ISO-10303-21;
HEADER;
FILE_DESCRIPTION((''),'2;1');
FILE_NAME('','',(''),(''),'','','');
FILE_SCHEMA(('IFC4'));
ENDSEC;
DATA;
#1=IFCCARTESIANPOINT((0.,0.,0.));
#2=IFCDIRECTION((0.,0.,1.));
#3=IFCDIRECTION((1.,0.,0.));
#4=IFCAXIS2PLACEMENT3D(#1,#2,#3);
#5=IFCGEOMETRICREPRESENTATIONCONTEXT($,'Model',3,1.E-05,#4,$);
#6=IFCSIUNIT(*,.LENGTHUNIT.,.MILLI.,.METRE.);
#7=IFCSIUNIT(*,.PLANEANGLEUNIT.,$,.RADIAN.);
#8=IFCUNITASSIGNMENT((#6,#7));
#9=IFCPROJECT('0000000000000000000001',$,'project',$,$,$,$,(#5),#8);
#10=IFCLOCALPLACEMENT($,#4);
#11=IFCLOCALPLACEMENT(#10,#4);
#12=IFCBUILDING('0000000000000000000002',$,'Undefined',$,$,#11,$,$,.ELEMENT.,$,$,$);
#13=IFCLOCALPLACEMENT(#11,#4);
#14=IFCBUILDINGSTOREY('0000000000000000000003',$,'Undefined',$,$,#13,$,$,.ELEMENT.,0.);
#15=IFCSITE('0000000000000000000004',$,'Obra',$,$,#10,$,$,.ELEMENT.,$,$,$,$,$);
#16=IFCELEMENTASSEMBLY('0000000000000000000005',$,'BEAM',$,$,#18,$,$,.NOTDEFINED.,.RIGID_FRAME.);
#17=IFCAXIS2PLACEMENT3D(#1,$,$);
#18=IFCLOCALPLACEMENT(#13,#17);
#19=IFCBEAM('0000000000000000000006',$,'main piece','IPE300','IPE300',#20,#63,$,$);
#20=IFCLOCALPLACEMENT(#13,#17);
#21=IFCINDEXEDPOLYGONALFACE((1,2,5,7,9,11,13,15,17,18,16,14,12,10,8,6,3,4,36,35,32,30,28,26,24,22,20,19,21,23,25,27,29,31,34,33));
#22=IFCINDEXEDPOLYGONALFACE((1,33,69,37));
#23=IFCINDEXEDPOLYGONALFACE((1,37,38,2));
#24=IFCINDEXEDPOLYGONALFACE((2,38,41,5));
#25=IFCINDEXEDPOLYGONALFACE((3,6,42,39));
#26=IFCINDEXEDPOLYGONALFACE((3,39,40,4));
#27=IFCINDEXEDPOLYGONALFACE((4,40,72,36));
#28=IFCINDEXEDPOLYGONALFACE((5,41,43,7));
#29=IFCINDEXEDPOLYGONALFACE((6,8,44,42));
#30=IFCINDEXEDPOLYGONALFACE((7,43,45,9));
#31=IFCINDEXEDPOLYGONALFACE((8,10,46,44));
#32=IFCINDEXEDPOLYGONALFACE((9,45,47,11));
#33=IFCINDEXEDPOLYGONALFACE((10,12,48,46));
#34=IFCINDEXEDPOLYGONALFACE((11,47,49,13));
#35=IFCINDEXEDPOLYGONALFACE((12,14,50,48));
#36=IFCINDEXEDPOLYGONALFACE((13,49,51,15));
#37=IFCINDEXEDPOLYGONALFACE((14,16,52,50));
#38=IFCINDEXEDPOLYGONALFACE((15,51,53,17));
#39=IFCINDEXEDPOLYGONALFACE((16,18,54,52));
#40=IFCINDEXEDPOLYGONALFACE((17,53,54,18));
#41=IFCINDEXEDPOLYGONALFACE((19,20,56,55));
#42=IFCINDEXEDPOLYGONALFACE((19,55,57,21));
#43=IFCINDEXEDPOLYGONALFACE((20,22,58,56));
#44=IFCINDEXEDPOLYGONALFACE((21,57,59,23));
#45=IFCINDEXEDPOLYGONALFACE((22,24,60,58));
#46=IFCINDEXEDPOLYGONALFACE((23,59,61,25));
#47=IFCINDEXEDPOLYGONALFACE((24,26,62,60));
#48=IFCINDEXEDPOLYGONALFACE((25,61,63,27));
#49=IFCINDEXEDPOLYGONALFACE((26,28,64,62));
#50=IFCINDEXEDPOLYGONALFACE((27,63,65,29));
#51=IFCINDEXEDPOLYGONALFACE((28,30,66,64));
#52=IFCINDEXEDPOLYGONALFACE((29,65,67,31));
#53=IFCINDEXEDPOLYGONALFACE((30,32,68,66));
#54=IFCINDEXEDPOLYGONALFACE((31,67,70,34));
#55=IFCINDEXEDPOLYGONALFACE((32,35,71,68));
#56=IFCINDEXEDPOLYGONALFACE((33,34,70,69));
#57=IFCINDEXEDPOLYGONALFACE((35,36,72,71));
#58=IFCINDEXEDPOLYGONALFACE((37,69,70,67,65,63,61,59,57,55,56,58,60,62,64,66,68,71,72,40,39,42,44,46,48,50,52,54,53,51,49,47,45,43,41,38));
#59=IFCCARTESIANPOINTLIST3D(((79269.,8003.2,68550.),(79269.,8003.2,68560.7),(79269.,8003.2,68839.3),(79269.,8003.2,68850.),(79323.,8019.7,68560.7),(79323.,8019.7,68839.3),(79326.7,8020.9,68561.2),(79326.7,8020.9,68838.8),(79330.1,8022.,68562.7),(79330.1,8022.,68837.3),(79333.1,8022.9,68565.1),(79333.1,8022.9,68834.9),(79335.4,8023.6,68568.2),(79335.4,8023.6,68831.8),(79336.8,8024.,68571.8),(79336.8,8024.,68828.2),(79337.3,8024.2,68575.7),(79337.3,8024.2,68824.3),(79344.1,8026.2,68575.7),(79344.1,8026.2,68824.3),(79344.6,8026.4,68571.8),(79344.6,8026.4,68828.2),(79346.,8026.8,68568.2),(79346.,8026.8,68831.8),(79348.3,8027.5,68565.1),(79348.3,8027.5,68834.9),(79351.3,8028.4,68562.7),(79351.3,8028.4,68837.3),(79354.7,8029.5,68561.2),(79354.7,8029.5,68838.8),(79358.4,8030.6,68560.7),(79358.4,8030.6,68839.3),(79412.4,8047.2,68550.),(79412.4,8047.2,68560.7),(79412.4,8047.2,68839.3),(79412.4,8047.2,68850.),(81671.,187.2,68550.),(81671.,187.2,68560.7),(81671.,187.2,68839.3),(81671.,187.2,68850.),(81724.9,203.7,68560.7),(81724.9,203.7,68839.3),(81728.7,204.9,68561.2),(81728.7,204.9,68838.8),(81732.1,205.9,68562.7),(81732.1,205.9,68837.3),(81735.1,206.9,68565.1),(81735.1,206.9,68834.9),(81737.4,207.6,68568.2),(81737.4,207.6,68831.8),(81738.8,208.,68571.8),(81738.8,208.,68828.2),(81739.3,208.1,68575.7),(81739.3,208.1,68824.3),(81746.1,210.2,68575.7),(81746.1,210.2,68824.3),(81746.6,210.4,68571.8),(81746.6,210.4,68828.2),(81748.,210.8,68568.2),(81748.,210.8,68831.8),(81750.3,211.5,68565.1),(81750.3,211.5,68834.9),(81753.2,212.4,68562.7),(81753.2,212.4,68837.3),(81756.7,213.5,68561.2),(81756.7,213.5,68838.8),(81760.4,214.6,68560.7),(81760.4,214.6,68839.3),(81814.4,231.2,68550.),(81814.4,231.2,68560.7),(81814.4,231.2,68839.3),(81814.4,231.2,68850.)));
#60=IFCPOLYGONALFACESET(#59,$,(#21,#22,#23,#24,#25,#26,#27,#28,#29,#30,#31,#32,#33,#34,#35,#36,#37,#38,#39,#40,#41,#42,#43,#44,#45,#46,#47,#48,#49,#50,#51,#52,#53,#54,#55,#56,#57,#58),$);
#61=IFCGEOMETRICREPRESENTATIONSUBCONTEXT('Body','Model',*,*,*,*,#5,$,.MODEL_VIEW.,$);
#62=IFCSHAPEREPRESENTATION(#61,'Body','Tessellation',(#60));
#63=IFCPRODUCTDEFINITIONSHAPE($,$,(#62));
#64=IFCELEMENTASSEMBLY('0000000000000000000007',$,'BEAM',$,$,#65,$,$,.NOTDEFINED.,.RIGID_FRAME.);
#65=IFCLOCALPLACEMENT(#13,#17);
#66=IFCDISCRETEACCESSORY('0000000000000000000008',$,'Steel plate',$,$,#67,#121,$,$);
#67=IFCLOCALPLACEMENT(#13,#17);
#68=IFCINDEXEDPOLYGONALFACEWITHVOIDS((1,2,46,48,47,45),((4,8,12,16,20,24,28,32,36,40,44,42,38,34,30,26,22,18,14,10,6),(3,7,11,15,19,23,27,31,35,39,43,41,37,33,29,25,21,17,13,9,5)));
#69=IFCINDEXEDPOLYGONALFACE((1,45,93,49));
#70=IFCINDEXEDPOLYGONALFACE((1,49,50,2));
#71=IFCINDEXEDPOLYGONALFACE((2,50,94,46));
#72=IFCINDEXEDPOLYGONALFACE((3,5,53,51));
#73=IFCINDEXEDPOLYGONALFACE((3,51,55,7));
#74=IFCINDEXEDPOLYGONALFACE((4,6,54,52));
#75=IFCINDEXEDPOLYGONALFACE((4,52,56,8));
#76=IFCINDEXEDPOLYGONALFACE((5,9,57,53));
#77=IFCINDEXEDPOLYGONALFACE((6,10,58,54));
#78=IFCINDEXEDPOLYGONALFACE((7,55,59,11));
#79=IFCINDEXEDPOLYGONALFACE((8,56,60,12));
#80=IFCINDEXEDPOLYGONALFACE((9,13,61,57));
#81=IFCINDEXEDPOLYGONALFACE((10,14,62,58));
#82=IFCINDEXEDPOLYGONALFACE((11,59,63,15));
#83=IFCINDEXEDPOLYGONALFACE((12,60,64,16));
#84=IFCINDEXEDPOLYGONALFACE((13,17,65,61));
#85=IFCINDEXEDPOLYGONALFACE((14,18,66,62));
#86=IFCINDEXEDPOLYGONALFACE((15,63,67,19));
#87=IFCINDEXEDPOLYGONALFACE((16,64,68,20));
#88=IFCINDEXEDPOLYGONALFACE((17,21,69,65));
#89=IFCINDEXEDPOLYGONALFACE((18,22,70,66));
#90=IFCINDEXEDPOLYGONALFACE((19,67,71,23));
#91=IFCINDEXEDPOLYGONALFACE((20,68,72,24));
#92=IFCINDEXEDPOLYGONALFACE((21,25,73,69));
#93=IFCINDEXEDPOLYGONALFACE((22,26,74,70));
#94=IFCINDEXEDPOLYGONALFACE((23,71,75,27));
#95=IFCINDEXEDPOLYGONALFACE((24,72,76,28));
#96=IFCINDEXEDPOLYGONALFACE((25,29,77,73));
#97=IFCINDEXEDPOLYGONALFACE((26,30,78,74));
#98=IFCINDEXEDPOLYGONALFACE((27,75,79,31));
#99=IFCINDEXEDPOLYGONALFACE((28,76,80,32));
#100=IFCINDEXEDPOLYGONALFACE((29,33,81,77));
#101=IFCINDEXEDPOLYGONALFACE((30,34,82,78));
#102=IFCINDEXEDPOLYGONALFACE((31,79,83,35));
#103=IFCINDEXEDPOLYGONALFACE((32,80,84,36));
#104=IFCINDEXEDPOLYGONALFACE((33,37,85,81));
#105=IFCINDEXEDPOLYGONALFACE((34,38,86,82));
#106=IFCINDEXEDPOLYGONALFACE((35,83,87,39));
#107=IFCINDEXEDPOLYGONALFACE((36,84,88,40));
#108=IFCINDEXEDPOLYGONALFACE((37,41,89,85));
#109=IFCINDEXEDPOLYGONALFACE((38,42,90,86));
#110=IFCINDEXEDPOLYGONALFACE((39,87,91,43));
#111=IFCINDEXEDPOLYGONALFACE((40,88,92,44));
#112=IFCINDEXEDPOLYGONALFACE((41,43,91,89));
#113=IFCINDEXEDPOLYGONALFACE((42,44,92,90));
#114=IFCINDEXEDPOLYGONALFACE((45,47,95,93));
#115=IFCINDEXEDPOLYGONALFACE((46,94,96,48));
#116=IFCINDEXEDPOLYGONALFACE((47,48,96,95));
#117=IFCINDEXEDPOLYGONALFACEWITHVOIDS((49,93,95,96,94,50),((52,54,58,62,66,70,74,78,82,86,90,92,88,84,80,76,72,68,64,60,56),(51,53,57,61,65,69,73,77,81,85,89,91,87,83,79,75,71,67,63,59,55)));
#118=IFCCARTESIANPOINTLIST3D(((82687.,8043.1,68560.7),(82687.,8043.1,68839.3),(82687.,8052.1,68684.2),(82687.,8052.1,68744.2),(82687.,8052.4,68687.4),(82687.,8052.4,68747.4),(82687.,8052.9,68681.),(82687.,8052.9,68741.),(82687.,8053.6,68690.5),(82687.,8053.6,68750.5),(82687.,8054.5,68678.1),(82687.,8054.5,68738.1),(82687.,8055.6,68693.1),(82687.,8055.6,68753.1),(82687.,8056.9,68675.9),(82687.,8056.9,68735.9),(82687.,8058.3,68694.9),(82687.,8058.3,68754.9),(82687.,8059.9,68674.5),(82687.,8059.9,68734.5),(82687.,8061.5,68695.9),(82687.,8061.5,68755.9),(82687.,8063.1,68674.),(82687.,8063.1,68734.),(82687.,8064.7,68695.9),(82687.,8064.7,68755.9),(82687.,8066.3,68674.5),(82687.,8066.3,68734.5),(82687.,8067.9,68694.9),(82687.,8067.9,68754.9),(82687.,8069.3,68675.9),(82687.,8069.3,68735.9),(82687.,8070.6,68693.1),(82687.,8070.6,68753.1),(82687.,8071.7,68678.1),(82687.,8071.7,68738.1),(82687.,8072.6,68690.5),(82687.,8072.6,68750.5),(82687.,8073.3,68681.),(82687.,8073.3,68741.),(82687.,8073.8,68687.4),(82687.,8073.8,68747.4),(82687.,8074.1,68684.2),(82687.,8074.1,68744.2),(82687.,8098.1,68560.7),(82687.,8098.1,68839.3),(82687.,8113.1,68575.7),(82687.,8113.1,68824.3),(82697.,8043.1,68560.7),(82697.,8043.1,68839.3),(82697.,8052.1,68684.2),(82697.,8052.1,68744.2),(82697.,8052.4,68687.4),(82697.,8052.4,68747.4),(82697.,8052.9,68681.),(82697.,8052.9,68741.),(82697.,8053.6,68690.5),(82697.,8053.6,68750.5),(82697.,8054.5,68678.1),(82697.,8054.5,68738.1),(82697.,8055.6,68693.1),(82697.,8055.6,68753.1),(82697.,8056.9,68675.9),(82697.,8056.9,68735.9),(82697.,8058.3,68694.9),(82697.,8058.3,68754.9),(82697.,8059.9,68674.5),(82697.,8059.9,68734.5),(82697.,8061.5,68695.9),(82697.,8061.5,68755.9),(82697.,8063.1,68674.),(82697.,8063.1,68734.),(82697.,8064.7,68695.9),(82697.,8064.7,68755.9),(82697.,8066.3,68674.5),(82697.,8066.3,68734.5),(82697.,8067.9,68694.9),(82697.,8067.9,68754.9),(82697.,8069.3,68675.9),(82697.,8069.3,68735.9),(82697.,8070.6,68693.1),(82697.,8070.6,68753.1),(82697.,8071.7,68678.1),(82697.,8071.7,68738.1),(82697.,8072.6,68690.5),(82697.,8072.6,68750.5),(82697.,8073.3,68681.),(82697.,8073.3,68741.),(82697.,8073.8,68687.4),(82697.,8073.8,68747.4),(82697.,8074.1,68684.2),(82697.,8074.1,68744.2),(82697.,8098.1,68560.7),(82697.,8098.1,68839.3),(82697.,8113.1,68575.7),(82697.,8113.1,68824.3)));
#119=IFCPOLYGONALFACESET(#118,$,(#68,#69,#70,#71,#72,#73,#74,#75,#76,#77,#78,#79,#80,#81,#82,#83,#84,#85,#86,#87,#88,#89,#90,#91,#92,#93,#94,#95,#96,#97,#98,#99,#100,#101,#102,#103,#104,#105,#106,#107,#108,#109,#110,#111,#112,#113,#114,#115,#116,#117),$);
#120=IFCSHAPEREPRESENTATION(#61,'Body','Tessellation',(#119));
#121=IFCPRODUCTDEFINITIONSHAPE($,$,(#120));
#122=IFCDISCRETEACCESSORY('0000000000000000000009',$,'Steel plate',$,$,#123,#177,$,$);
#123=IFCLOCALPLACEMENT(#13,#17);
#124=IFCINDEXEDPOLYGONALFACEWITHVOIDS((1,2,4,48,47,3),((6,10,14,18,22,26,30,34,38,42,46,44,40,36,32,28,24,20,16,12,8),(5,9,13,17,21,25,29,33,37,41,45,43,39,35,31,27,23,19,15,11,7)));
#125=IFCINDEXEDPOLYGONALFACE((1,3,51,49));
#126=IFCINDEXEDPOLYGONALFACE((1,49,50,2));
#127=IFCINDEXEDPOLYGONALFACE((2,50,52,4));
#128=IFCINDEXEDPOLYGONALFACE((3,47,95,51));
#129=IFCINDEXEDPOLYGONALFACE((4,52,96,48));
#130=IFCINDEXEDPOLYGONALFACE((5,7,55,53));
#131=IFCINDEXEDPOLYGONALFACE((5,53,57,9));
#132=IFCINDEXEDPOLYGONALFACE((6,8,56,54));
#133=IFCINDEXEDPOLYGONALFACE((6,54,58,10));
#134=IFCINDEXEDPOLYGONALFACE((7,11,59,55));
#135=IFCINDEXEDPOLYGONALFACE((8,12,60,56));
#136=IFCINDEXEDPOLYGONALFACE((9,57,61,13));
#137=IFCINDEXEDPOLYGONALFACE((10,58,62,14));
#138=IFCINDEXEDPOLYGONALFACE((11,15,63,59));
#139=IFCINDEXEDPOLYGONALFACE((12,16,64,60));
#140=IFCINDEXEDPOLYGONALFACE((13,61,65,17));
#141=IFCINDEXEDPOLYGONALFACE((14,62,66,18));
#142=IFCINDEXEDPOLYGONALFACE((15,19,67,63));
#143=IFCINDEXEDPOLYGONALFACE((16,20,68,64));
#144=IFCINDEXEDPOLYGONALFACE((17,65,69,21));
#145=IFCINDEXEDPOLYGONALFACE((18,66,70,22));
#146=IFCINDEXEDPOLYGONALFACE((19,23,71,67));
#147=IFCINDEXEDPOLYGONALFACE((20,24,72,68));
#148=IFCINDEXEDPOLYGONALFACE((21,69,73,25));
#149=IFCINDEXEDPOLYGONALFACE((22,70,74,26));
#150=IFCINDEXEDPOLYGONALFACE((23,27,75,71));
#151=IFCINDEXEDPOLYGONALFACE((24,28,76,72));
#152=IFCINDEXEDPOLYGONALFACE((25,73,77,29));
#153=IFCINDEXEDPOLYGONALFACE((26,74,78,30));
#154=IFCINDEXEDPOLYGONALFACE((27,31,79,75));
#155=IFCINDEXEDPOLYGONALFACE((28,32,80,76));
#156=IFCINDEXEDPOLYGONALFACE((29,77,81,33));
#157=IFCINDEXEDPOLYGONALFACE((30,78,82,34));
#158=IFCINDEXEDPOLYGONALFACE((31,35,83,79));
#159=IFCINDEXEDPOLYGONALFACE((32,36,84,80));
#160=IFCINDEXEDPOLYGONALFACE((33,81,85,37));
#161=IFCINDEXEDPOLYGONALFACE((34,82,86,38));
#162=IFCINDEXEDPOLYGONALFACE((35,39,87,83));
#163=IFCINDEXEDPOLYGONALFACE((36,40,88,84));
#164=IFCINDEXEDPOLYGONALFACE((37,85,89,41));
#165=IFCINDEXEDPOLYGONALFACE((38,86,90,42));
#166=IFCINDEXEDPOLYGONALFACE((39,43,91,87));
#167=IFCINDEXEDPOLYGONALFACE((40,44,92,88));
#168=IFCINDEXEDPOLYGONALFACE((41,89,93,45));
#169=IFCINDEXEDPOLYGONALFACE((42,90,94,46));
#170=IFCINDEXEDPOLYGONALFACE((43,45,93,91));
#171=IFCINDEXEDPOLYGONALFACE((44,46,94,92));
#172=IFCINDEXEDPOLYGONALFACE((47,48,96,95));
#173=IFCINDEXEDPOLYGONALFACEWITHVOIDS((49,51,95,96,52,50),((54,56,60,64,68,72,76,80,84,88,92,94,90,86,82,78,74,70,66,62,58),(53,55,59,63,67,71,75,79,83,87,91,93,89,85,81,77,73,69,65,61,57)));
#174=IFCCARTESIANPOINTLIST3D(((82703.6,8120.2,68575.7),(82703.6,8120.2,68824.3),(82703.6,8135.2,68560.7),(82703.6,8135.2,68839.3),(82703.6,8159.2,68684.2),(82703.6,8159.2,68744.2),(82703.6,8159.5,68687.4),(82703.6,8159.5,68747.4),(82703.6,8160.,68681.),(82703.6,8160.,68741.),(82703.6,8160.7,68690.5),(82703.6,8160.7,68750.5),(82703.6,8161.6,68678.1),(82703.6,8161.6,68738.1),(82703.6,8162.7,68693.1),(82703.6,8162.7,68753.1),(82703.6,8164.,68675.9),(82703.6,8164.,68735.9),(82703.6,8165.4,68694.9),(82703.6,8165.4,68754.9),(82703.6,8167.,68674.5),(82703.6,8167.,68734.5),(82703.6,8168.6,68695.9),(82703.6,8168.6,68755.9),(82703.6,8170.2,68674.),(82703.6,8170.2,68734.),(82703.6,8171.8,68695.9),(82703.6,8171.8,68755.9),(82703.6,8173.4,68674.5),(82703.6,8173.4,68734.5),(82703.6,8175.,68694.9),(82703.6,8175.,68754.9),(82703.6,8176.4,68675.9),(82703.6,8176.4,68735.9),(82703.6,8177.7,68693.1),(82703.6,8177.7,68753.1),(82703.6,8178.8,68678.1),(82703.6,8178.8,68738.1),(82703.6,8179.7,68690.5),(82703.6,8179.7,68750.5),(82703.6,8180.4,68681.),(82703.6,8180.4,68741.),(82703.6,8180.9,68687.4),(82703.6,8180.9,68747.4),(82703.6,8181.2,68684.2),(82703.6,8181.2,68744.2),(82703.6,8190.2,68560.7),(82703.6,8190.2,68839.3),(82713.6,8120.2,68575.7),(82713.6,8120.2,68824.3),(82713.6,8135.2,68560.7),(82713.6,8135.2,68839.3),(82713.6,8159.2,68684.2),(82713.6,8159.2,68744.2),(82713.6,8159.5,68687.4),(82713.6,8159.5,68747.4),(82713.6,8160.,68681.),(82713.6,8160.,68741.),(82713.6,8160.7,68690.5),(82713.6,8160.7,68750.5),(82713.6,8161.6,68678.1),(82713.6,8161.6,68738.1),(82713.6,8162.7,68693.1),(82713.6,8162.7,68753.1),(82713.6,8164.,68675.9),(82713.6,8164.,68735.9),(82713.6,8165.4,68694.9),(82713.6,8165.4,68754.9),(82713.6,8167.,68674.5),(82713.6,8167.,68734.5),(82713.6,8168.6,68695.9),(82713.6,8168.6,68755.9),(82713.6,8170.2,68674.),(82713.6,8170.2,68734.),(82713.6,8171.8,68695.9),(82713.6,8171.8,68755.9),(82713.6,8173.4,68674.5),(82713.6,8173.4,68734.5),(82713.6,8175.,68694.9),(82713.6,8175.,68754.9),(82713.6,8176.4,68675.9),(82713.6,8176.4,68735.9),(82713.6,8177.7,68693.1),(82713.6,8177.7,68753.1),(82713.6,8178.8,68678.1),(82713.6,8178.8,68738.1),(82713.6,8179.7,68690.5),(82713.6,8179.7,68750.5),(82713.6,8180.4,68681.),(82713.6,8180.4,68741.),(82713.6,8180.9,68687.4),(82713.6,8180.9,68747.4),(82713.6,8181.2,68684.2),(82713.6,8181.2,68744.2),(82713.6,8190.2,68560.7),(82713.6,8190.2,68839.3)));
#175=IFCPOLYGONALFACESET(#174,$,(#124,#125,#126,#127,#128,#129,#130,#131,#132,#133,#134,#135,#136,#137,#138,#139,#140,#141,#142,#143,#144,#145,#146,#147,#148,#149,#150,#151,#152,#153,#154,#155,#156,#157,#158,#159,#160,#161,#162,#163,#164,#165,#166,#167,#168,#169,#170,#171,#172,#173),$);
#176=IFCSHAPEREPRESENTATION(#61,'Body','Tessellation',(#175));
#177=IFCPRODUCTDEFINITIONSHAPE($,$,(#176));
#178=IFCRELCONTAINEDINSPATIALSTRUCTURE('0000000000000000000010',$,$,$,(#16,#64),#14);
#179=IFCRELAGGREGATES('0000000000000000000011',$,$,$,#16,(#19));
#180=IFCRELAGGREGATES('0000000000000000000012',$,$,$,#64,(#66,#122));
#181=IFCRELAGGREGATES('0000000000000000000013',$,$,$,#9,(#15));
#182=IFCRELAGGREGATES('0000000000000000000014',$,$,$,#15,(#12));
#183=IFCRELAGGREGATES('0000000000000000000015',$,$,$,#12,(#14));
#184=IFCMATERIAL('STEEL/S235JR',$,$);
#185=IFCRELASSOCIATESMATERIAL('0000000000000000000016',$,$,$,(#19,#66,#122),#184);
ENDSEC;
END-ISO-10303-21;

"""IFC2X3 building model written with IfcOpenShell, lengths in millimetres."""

from ifc_helpers import new_model, si_unit, frame, origin_with_axes, origin_2d_with_axis, place, context, subcontext, project, spatial, polyline, circle, i_section, outline, extrude, source, transform, mapped, material, element, aggregate, save


model = new_model("IFC2X3")

# Units and contexts
model_context = context("Model", 3, precision=1e-05, world=origin_with_axes())
body_context = subcontext(model_context, "Body", "Model", "MODEL_VIEW")
ifc_project = project(units=[si_unit("LENGTHUNIT", "METRE", prefix="MILLI"), si_unit("PLANEANGLEUNIT", "RADIAN")], contexts=[model_context])

# Site, building, storey
site_placement = place(None, origin_with_axes())
site = spatial("IfcSite", under=ifc_project, at=site_placement, Name="Obra", CompositionType="ELEMENT")
building_placement = place(site_placement, origin_with_axes())
building = spatial("IfcBuilding", under=site, at=building_placement, Name="Undefined", CompositionType="ELEMENT")
storey_placement = place(building_placement, origin_with_axes())
storey = spatial("IfcBuildingStorey", under=building, at=storey_placement, Name="Undefined", CompositionType="ELEMENT", Elevation=0.0)

# Shared definitions
ifc_material = material(Name="STEEL/S235JR")

# Element assembly, beam
assembly_1_placement = place(storey_placement, origin_with_axes())
assembly_1 = element("IfcElementAssembly", 1, at=assembly_1_placement, inside=storey, Name="BEAM", AssemblyPlace="NOTDEFINED", PredefinedType="RIGID_FRAME")
beam_1_placement = place(assembly_1_placement, frame((79340.7, 8025.2, 68700.0), z_axis=(0.0, 0.0, 1.0), x_axis=(0.293756, -0.955881, 0.0)))
beam_1 = element("IfcBeam", 2, at=beam_1_placement, material=ifc_material, Name="main piece", Description="IPE300", ObjectType="IPE300", context=body_context, shape_type="SweptSolid", body=[
    extrude(i_section(OverallWidth=150.0, OverallDepth=300.0, WebThickness=7.1, FlangeThickness=10.7, FilletRadius=15.0, at=origin_2d_with_axis()), frame((8176.8, 0.0, 0.0), z_axis=(-1.0, 0.0, 0.0), x_axis=(0.0, -1.0, 0.0)), (0.0, 0.0, 1.0), 8176.8),
])

# Element assembly, discrete accessories, openings
assembly_2_placement = place(storey_placement, origin_with_axes())
assembly_2 = element("IfcElementAssembly", 3, at=assembly_2_placement, inside=storey, Name="BEAM", AssemblyPlace="NOTDEFINED", PredefinedType="RIGID_FRAME")
discrete_accessory_1_placement = place(assembly_2_placement, frame((82692.0, 8043.1, 68560.7), z_axis=(1.0, 0.0, 0.0), x_axis=(0.0, 1.0, 0.0)))
discrete_accessory_1 = element("IfcDiscreteAccessory", 4, at=discrete_accessory_1_placement, material=ifc_material, Name="Steel plate", context=body_context, shape_type="SweptSolid", body=[
    extrude(outline(polyline([(0.0, 0.0), (55.0, 0.0), (70.0, 15.0), (70.0, 263.6), (55.0, 278.6), (0.0, 278.6), (0.0, 0.0)])), frame((0.0, 0.0, -5.0), z_axis=(0.0, 0.0, 1.0), x_axis=(1.0, 0.0, 0.0)), (0.0, 0.0, 1.0), 10.0),
])
shared_shape_1 = source(origin_with_axes(), body_context, "Body", "SweptSolid", [
    extrude(circle(Radius=11.0, at=origin_2d_with_axis()), frame((0.0, -13.4, 0.0), z_axis=(0.0, 1.0, 0.0), x_axis=(1.0, 0.0, 0.0)), (0.0, 0.0, 1.0), 10.2),
])
opening_1_placement = place(assembly_2_placement, frame((82700.3, 8103.1, 68850.0), z_axis=(0.0, -1.0, 0.0), x_axis=(0.0, 0.0, -1.0)))
element("IfcOpeningElement", 5, at=opening_1_placement, cuts=discrete_accessory_1, ObjectType="Opening", context=body_context, shape_type="MappedRepresentation", body=[
    mapped(shared_shape_1, transform((105.0, 0.0, 40.0))),
    mapped(shared_shape_1, transform((165.0, 0.0, 40.0))),
])
discrete_accessory_2_placement = place(assembly_2_placement, frame((82708.6, 8190.2, 68560.7), z_axis=(-1.0, 0.0, 0.0), x_axis=(0.0, -1.0, 0.0)))
discrete_accessory_2 = element("IfcDiscreteAccessory", 6, at=discrete_accessory_2_placement, material=ifc_material, Name="Steel plate", context=body_context, shape_type="SweptSolid", body=[
    extrude(outline(polyline([(0.0, 0.0), (55.0, 0.0), (70.0, 15.0), (70.0, 263.6), (55.0, 278.6), (0.0, 278.6), (0.0, 0.0)])), frame((0.0, 0.0, -5.0), z_axis=(0.0, 0.0, 1.0), x_axis=(1.0, 0.0, 0.0)), (0.0, 0.0, 1.0), 10.0),
])
opening_2_placement = place(assembly_2_placement, frame((82700.3, 8130.2, 68850.0), z_axis=(0.0, 1.0, 0.0), x_axis=(0.0, 0.0, -1.0)))
element("IfcOpeningElement", 7, at=opening_2_placement, cuts=discrete_accessory_2, ObjectType="Opening", context=body_context, shape_type="MappedRepresentation", body=[
    mapped(shared_shape_1, transform((105.0, 0.0, 40.0))),
    mapped(shared_shape_1, transform((165.0, 0.0, 40.0))),
])

aggregate(assembly_1, [beam_1])
aggregate(assembly_2, [discrete_accessory_1, discrete_accessory_2])

save(model, "model.ifc")
